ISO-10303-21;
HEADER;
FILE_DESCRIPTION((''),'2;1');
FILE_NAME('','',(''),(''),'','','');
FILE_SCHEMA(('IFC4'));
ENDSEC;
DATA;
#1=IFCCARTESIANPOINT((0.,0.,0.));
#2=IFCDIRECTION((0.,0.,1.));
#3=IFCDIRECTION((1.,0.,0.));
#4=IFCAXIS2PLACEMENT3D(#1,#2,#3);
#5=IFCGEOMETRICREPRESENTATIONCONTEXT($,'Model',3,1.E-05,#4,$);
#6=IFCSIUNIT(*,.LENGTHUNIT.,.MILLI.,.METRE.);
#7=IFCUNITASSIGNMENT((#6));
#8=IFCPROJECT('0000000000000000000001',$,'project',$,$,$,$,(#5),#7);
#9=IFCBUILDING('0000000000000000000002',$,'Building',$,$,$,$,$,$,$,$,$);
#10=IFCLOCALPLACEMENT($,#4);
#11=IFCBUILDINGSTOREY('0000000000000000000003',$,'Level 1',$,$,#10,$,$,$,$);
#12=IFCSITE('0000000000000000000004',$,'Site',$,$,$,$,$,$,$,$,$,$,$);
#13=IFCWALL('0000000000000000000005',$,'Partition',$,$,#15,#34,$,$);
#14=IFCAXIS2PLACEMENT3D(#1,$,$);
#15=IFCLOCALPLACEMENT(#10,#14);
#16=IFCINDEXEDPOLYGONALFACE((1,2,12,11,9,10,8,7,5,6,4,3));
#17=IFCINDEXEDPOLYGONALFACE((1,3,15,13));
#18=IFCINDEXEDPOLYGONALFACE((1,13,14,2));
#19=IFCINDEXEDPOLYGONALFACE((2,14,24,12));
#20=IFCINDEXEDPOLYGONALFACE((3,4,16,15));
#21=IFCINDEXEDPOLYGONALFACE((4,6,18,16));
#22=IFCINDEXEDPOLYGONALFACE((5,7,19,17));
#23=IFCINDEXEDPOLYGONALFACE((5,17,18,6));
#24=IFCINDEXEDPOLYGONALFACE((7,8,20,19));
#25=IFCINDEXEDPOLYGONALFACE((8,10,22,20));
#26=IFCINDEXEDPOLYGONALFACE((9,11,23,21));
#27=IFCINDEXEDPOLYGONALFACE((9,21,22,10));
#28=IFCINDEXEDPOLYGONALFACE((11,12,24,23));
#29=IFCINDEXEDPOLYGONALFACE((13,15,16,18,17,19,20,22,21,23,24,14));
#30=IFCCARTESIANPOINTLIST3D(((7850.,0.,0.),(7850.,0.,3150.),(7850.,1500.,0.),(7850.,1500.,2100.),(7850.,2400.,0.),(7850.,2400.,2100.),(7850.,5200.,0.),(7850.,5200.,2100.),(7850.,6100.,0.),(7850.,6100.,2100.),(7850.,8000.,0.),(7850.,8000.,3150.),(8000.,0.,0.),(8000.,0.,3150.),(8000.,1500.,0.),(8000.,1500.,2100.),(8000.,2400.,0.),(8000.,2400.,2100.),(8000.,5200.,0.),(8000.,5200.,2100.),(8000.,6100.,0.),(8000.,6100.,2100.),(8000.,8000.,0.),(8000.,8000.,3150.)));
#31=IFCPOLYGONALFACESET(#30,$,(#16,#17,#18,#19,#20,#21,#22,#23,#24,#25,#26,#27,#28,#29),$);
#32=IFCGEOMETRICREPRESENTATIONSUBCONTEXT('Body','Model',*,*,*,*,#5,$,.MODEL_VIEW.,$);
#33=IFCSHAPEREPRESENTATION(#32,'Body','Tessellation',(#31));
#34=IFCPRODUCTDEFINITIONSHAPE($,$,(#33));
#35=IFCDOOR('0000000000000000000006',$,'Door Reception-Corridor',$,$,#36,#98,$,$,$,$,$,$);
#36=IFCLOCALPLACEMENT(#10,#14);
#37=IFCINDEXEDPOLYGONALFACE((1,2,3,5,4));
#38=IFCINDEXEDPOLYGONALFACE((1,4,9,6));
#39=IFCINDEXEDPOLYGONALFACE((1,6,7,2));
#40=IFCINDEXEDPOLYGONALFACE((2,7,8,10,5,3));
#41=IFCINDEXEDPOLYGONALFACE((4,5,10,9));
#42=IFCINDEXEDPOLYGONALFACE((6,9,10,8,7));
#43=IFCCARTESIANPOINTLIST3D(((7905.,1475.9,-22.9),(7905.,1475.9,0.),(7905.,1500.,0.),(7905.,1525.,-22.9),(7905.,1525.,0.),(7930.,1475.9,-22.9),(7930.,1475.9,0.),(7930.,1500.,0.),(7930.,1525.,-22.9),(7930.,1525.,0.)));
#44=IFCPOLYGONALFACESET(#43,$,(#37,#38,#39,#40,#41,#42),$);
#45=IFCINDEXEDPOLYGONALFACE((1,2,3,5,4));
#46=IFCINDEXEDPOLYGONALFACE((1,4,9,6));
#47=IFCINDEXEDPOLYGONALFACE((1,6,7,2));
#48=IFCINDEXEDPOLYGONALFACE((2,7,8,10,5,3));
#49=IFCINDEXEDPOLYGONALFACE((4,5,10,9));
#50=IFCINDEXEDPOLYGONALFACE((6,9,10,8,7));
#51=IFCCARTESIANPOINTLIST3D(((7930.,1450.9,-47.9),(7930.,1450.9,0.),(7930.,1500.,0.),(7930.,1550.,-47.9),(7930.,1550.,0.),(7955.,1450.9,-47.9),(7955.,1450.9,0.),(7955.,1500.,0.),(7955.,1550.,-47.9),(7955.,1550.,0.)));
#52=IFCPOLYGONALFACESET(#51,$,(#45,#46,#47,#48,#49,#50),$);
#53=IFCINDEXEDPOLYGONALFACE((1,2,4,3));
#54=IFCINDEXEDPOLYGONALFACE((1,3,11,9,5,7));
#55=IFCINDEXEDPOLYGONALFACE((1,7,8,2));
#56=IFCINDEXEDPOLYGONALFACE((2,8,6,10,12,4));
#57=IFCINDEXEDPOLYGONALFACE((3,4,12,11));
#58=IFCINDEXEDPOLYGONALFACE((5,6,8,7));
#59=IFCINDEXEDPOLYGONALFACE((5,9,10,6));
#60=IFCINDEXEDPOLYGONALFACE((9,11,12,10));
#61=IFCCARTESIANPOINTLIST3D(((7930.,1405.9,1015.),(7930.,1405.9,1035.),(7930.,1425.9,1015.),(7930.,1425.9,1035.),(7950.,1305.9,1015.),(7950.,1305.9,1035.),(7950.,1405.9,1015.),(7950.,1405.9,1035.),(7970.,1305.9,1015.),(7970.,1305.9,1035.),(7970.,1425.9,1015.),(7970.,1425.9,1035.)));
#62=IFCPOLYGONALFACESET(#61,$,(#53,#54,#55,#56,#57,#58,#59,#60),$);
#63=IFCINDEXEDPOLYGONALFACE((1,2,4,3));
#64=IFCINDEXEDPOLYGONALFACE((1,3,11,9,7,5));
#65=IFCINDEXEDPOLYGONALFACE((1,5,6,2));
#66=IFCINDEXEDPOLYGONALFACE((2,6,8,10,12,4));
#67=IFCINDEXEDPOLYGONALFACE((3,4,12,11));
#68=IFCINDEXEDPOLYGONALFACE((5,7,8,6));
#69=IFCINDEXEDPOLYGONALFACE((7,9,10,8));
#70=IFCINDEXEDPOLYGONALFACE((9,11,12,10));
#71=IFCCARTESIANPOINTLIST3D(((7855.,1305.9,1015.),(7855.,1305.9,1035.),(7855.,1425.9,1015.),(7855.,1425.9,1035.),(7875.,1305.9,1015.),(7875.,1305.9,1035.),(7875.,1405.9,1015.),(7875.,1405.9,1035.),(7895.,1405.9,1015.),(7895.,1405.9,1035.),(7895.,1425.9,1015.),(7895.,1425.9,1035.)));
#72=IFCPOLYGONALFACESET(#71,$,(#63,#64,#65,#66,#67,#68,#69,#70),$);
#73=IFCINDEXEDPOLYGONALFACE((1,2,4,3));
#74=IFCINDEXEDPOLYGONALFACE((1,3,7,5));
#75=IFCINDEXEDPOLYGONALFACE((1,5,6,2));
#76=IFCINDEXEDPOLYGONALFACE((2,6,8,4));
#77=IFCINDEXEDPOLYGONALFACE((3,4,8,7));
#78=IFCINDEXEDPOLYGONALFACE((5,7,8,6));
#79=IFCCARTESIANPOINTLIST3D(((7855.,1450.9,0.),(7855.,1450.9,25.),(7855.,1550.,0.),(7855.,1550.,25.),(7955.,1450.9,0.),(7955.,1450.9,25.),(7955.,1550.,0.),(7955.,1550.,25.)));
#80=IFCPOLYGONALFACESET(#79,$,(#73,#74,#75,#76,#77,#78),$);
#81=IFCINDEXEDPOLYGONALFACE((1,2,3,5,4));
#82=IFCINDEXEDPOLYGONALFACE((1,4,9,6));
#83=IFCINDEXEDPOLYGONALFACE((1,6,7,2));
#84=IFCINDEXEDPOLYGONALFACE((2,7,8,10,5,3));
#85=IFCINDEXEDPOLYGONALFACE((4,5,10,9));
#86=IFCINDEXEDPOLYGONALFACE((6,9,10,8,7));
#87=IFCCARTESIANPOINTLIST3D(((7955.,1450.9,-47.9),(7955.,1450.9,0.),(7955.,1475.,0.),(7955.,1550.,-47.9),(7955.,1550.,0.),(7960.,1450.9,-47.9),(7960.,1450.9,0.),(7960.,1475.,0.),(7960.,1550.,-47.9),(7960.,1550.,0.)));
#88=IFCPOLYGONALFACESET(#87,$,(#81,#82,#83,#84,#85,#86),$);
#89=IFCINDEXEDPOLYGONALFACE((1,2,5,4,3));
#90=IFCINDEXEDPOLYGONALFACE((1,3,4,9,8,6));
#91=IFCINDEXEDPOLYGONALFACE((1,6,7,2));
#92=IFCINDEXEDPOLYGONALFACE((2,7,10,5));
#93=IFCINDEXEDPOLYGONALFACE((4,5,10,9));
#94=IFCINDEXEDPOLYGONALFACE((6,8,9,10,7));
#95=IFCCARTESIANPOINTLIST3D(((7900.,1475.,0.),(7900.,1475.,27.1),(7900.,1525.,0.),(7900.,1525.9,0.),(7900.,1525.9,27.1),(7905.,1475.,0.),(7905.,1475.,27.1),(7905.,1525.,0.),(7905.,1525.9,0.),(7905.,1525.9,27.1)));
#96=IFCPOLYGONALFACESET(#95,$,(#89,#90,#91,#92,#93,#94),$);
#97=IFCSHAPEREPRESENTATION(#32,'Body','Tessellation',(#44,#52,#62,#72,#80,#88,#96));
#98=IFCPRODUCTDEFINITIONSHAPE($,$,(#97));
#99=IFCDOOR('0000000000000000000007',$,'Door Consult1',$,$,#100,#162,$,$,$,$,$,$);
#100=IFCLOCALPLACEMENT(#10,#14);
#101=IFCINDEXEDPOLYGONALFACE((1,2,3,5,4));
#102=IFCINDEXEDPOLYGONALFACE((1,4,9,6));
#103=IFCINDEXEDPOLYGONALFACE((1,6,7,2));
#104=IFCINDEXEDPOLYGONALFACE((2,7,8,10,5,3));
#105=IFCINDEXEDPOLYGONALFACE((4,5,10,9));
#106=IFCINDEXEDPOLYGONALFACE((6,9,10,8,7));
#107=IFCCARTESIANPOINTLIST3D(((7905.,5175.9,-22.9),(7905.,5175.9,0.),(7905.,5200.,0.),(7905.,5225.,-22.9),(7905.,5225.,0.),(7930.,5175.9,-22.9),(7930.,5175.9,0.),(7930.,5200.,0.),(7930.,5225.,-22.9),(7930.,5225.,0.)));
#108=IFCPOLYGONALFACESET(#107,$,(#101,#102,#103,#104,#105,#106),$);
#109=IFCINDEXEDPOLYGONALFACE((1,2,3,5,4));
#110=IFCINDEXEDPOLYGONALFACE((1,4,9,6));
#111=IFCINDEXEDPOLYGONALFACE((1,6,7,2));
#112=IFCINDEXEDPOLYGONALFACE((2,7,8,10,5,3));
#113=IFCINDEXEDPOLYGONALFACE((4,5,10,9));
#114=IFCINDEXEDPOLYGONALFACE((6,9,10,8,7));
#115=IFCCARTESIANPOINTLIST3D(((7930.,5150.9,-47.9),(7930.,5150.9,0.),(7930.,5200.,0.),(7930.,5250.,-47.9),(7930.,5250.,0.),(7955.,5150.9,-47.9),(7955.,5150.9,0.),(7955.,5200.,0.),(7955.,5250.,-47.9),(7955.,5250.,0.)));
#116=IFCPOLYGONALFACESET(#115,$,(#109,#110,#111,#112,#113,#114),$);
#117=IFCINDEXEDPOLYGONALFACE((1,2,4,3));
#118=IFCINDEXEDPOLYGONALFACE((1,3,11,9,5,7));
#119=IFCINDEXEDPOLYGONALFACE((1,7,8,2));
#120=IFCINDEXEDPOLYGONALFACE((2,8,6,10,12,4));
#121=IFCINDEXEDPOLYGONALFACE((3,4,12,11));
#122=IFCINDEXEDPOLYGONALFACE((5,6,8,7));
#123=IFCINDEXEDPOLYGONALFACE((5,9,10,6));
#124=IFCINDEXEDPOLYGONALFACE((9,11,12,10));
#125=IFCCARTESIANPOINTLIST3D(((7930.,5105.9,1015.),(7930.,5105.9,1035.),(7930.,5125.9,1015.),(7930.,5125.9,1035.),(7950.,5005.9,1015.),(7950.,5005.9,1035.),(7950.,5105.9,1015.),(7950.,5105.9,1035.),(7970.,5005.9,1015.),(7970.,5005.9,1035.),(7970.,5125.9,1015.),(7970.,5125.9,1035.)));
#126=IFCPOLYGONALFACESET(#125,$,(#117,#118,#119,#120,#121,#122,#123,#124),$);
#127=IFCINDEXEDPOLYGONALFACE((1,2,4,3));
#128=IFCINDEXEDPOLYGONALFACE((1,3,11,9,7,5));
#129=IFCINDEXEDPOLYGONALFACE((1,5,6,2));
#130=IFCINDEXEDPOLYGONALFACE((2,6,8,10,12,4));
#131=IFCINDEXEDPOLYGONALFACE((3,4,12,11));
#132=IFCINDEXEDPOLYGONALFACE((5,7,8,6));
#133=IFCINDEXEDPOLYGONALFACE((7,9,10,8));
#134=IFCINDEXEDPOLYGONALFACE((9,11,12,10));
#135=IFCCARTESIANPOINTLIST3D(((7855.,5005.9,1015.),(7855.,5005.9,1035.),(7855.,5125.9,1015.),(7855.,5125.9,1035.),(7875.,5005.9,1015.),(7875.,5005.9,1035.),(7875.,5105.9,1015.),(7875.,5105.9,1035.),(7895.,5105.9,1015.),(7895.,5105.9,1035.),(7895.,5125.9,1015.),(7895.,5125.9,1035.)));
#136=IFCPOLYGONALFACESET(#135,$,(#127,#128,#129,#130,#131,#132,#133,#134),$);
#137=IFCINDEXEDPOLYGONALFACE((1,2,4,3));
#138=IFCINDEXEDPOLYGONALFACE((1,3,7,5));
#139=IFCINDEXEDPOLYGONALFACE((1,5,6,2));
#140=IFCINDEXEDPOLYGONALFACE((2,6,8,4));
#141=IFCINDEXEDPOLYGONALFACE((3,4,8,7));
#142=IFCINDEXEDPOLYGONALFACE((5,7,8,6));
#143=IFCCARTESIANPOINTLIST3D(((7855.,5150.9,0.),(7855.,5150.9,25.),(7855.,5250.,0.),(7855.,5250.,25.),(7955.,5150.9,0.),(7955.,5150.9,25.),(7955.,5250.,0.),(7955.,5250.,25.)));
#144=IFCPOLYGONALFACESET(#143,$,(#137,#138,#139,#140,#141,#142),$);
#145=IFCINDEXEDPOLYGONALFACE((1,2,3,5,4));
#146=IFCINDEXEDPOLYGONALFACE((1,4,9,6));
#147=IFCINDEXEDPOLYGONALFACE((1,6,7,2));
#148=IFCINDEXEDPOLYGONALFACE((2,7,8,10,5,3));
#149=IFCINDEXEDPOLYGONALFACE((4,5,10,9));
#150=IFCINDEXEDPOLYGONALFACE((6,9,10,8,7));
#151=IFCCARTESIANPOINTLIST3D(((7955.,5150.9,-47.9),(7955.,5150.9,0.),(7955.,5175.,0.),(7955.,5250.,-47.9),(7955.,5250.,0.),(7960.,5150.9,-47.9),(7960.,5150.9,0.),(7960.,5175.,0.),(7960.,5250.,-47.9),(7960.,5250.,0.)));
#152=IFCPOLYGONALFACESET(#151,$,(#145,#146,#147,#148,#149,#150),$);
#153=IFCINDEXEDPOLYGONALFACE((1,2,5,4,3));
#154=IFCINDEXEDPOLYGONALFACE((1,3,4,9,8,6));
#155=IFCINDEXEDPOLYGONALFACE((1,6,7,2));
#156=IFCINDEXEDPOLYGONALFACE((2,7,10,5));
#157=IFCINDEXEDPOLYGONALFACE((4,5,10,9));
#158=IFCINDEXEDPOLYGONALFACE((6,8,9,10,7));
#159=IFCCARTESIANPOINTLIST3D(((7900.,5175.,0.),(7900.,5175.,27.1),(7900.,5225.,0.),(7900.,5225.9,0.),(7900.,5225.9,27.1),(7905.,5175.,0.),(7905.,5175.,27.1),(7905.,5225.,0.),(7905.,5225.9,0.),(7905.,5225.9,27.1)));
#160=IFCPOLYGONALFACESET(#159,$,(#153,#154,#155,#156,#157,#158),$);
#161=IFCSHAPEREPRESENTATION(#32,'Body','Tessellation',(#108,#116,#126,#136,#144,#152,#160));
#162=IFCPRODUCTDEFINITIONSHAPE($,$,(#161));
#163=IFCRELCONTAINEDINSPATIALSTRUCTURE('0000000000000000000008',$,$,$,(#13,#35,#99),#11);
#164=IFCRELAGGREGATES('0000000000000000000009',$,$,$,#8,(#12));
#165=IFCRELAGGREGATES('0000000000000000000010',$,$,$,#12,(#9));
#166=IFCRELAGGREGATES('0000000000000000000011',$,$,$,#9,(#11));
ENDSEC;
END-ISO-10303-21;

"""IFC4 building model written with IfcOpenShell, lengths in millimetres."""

from ifc_helpers import new_model, si_unit, frame, origin_with_axes, place, context, subcontext, project, spatial, line, indexed_curve, outline, extrude, element, fill, save


model = new_model("IFC4")

# Units and contexts
model_context = context("Model", 3, precision=1e-05, world=origin_with_axes())
body_context = subcontext(model_context, "Body", "Model", "MODEL_VIEW")
ifc_project = project(units=[si_unit("LENGTHUNIT", "METRE", prefix="MILLI")], contexts=[model_context])

# Site, building, storey
site = spatial("IfcSite", under=ifc_project, Name="Site")
building = spatial("IfcBuilding", under=site, Name="Building")
storey_placement = place(None, origin_with_axes())
storey = spatial("IfcBuildingStorey", under=building, at=storey_placement, Name="Level 1")

# Wall, openings, doors
wall_1_placement = place(storey_placement, frame((8000.0, 0.0, 0.0), z_axis=(0.0, 0.0, 1.0), x_axis=(0.0, 1.0, 0.0)))
wall_1 = element("IfcWall", 1, at=wall_1_placement, inside=storey, Name="Partition", context=body_context, shape_type="SweptSolid", body=[
    extrude(outline(indexed_curve([(0.0, 0.0), (0.0, 150.0), (8000.0, 150.0), (8000.0, 0.0), (0.0, 0.0)], self_intersect=False)), origin_with_axes(), (0.0, 0.0, 1.0), 3150.0),
])
opening_1_placement = place(wall_1_placement, frame((1500.0, -100.0, 0.0), z_axis=(0.0, 0.0, 1.0), x_axis=(1.0, 0.0, 0.0)))
opening_1 = element("IfcOpeningElement", 2, at=opening_1_placement, cuts=wall_1, context=body_context, shape_type="SweptSolid", body=[
    extrude(outline(indexed_curve([(0.0, 0.0), (0.0, 350.0), (900.0, 350.0), (900.0, 0.0), (0.0, 0.0)], self_intersect=False)), origin_with_axes(), (0.0, 0.0, 1.0), 2100.0),
])
opening_2_placement = place(wall_1_placement, frame((5200.0, -100.0, 0.0), z_axis=(0.0, 0.0, 1.0), x_axis=(1.0, 0.0, 0.0)))
opening_2 = element("IfcOpeningElement", 3, at=opening_2_placement, cuts=wall_1, context=body_context, shape_type="SweptSolid", body=[
    extrude(outline(indexed_curve([(0.0, 0.0), (0.0, 350.0), (900.0, 350.0), (900.0, 0.0), (0.0, 0.0)], self_intersect=False)), origin_with_axes(), (0.0, 0.0, 1.0), 2100.0),
])
door_1_placement = place(opening_1_placement, frame((0.0, 145.0, 0.0), z_axis=(0.0, 0.0, 1.0), x_axis=(1.0, 0.0, 0.0)))
door_1 = element("IfcDoor", 4, at=door_1_placement, inside=storey, Name="Door Reception-Corridor", context=body_context, shape_type="SweptSolid", body=[
    extrude(outline(indexed_curve([(0.0, 0.0), (0.0, 2.1), (0.9, 2.1), (0.9, 0.0), (-24.1, 0.0), (-24.1, -22.9), (25.0, -22.9), (25.0, 0.0)], segments=[line(1, 2, 3, 4, 5, 6, 7, 8, 1)])), frame((0.0, 25.0, 0.0), z_axis=(0.0, -1.0, 0.0), x_axis=(1.0, 0.0, 0.0)), (0.0, 0.0, -1.0), 25.0),
    extrude(outline(indexed_curve([(0.0, 0.0), (0.0, 2.1), (0.9, 2.1), (0.9, 0.0), (-49.1, 0.0), (-49.1, -47.9), (50.0, -47.9), (50.0, 0.0)], segments=[line(1, 2, 3, 4, 5, 6, 7, 8, 1)])), frame((0.0, 0.0, 0.0), z_axis=(0.0, -1.0, 0.0), x_axis=(1.0, 0.0, 0.0)), (0.0, 0.0, -1.0), 25.0),
    extrude(outline(indexed_curve([(0.0, 0.0), (-49.1, 0.0), (-49.1, 35.0), (0.0, 35.0)], segments=[line(1, 2, 3, 4, 1)])), frame((25.0, 25.0, 25.0), z_axis=(0.0, 0.0, 1.0), x_axis=(1.0, 0.0, 0.0)), (0.0, 0.0, 1.0), -47.9),
    extrude(outline(indexed_curve([(0.0, 0.0), (0.0, -40.0), (-120.0, -40.0), (-120.0, -20.0), (-20.0, -20.0), (-20.0, 0.0)], segments=[line(1, 2, 3, 4, 5, 6, 1)])), frame((-74.1, 25.0, 1015.0), z_axis=(0.0, 0.0, 1.0), x_axis=(1.0, 0.0, 0.0)), (0.0, 0.0, 1.0), 20.0),
    extrude(outline(indexed_curve([(0.0, 0.0), (0.0, 40.0), (-120.0, 40.0), (-120.0, 20.0), (-20.0, 20.0), (-20.0, 0.0)], segments=[line(1, 2, 3, 4, 5, 6, 1)])), frame((-74.1, 60.0, 1015.0), z_axis=(0.0, 0.0, 1.0), x_axis=(1.0, 0.0, 0.0)), (0.0, 0.0, 1.0), 20.0),
    extrude(outline(indexed_curve([(0.0, 0.0), (-99.1, 0.0), (-99.1, 100.0), (0.0, 100.0)], segments=[line(1, 2, 3, 4, 1)])), frame((50.0, 0.0, 0.0), z_axis=(0.0, 0.0, 1.0), x_axis=(1.0, 0.0, 0.0)), (0.0, 0.0, 1.0), 25.0),
    extrude(outline(indexed_curve([(0.0, 0.0), (0.0, 27.1), (50.9, 27.1), (50.9, 0.0), (-24.1, 0.0), (-24.1, -47.9), (75.0, -47.9), (75.0, 0.0)], segments=[line(1, 2, 3, 4, 5, 6, 7, 8, 1)])), frame((-25.0, -5.0, 0.0), z_axis=(0.0, -1.0, 0.0), x_axis=(1.0, 0.0, 0.0)), (0.0, 0.0, -1.0), 5.0),
    extrude(outline(indexed_curve([(0.0, 0.0), (0.0, 27.1), (50.9, 27.1), (50.9, 0.0), (0.9, 0.0), (0.9, -22.9), (50.0, -22.9), (50.0, 0.0)], segments=[line(1, 2, 3, 4, 5, 6, 7, 8, 1)])), frame((-25.0, 50.0, 0.0), z_axis=(0.0, -1.0, 0.0), x_axis=(1.0, 0.0, 0.0)), (0.0, 0.0, -1.0), 5.0),
])
fill(opening_1, door_1)
door_2_placement = place(opening_2_placement, frame((0.0, 145.0, 0.0), z_axis=(0.0, 0.0, 1.0), x_axis=(1.0, 0.0, 0.0)))
door_2 = element("IfcDoor", 5, at=door_2_placement, inside=storey, Name="Door Consult1", context=body_context, shape_type="SweptSolid", body=[
    extrude(outline(indexed_curve([(0.0, 0.0), (0.0, 2.1), (0.9, 2.1), (0.9, 0.0), (-24.1, 0.0), (-24.1, -22.9), (25.0, -22.9), (25.0, 0.0)], segments=[line(1, 2, 3, 4, 5, 6, 7, 8, 1)])), frame((0.0, 25.0, 0.0), z_axis=(0.0, -1.0, 0.0), x_axis=(1.0, 0.0, 0.0)), (0.0, 0.0, -1.0), 25.0),
    extrude(outline(indexed_curve([(0.0, 0.0), (0.0, 2.1), (0.9, 2.1), (0.9, 0.0), (-49.1, 0.0), (-49.1, -47.9), (50.0, -47.9), (50.0, 0.0)], segments=[line(1, 2, 3, 4, 5, 6, 7, 8, 1)])), frame((0.0, 0.0, 0.0), z_axis=(0.0, -1.0, 0.0), x_axis=(1.0, 0.0, 0.0)), (0.0, 0.0, -1.0), 25.0),
    extrude(outline(indexed_curve([(0.0, 0.0), (-49.1, 0.0), (-49.1, 35.0), (0.0, 35.0)], segments=[line(1, 2, 3, 4, 1)])), frame((25.0, 25.0, 25.0), z_axis=(0.0, 0.0, 1.0), x_axis=(1.0, 0.0, 0.0)), (0.0, 0.0, 1.0), -47.9),
    extrude(outline(indexed_curve([(0.0, 0.0), (0.0, -40.0), (-120.0, -40.0), (-120.0, -20.0), (-20.0, -20.0), (-20.0, 0.0)], segments=[line(1, 2, 3, 4, 5, 6, 1)])), frame((-74.1, 25.0, 1015.0), z_axis=(0.0, 0.0, 1.0), x_axis=(1.0, 0.0, 0.0)), (0.0, 0.0, 1.0), 20.0),
    extrude(outline(indexed_curve([(0.0, 0.0), (0.0, 40.0), (-120.0, 40.0), (-120.0, 20.0), (-20.0, 20.0), (-20.0, 0.0)], segments=[line(1, 2, 3, 4, 5, 6, 1)])), frame((-74.1, 60.0, 1015.0), z_axis=(0.0, 0.0, 1.0), x_axis=(1.0, 0.0, 0.0)), (0.0, 0.0, 1.0), 20.0),
    extrude(outline(indexed_curve([(0.0, 0.0), (-99.1, 0.0), (-99.1, 100.0), (0.0, 100.0)], segments=[line(1, 2, 3, 4, 1)])), frame((50.0, 0.0, 0.0), z_axis=(0.0, 0.0, 1.0), x_axis=(1.0, 0.0, 0.0)), (0.0, 0.0, 1.0), 25.0),
    extrude(outline(indexed_curve([(0.0, 0.0), (0.0, 27.1), (50.9, 27.1), (50.9, 0.0), (-24.1, 0.0), (-24.1, -47.9), (75.0, -47.9), (75.0, 0.0)], segments=[line(1, 2, 3, 4, 5, 6, 7, 8, 1)])), frame((-25.0, -5.0, 0.0), z_axis=(0.0, -1.0, 0.0), x_axis=(1.0, 0.0, 0.0)), (0.0, 0.0, -1.0), 5.0),
    extrude(outline(indexed_curve([(0.0, 0.0), (0.0, 27.1), (50.9, 27.1), (50.9, 0.0), (0.9, 0.0), (0.9, -22.9), (50.0, -22.9), (50.0, 0.0)], segments=[line(1, 2, 3, 4, 5, 6, 7, 8, 1)])), frame((-25.0, 50.0, 0.0), z_axis=(0.0, -1.0, 0.0), x_axis=(1.0, 0.0, 0.0)), (0.0, 0.0, -1.0), 5.0),
])
fill(opening_2, door_2)

save(model, "model.ifc")
